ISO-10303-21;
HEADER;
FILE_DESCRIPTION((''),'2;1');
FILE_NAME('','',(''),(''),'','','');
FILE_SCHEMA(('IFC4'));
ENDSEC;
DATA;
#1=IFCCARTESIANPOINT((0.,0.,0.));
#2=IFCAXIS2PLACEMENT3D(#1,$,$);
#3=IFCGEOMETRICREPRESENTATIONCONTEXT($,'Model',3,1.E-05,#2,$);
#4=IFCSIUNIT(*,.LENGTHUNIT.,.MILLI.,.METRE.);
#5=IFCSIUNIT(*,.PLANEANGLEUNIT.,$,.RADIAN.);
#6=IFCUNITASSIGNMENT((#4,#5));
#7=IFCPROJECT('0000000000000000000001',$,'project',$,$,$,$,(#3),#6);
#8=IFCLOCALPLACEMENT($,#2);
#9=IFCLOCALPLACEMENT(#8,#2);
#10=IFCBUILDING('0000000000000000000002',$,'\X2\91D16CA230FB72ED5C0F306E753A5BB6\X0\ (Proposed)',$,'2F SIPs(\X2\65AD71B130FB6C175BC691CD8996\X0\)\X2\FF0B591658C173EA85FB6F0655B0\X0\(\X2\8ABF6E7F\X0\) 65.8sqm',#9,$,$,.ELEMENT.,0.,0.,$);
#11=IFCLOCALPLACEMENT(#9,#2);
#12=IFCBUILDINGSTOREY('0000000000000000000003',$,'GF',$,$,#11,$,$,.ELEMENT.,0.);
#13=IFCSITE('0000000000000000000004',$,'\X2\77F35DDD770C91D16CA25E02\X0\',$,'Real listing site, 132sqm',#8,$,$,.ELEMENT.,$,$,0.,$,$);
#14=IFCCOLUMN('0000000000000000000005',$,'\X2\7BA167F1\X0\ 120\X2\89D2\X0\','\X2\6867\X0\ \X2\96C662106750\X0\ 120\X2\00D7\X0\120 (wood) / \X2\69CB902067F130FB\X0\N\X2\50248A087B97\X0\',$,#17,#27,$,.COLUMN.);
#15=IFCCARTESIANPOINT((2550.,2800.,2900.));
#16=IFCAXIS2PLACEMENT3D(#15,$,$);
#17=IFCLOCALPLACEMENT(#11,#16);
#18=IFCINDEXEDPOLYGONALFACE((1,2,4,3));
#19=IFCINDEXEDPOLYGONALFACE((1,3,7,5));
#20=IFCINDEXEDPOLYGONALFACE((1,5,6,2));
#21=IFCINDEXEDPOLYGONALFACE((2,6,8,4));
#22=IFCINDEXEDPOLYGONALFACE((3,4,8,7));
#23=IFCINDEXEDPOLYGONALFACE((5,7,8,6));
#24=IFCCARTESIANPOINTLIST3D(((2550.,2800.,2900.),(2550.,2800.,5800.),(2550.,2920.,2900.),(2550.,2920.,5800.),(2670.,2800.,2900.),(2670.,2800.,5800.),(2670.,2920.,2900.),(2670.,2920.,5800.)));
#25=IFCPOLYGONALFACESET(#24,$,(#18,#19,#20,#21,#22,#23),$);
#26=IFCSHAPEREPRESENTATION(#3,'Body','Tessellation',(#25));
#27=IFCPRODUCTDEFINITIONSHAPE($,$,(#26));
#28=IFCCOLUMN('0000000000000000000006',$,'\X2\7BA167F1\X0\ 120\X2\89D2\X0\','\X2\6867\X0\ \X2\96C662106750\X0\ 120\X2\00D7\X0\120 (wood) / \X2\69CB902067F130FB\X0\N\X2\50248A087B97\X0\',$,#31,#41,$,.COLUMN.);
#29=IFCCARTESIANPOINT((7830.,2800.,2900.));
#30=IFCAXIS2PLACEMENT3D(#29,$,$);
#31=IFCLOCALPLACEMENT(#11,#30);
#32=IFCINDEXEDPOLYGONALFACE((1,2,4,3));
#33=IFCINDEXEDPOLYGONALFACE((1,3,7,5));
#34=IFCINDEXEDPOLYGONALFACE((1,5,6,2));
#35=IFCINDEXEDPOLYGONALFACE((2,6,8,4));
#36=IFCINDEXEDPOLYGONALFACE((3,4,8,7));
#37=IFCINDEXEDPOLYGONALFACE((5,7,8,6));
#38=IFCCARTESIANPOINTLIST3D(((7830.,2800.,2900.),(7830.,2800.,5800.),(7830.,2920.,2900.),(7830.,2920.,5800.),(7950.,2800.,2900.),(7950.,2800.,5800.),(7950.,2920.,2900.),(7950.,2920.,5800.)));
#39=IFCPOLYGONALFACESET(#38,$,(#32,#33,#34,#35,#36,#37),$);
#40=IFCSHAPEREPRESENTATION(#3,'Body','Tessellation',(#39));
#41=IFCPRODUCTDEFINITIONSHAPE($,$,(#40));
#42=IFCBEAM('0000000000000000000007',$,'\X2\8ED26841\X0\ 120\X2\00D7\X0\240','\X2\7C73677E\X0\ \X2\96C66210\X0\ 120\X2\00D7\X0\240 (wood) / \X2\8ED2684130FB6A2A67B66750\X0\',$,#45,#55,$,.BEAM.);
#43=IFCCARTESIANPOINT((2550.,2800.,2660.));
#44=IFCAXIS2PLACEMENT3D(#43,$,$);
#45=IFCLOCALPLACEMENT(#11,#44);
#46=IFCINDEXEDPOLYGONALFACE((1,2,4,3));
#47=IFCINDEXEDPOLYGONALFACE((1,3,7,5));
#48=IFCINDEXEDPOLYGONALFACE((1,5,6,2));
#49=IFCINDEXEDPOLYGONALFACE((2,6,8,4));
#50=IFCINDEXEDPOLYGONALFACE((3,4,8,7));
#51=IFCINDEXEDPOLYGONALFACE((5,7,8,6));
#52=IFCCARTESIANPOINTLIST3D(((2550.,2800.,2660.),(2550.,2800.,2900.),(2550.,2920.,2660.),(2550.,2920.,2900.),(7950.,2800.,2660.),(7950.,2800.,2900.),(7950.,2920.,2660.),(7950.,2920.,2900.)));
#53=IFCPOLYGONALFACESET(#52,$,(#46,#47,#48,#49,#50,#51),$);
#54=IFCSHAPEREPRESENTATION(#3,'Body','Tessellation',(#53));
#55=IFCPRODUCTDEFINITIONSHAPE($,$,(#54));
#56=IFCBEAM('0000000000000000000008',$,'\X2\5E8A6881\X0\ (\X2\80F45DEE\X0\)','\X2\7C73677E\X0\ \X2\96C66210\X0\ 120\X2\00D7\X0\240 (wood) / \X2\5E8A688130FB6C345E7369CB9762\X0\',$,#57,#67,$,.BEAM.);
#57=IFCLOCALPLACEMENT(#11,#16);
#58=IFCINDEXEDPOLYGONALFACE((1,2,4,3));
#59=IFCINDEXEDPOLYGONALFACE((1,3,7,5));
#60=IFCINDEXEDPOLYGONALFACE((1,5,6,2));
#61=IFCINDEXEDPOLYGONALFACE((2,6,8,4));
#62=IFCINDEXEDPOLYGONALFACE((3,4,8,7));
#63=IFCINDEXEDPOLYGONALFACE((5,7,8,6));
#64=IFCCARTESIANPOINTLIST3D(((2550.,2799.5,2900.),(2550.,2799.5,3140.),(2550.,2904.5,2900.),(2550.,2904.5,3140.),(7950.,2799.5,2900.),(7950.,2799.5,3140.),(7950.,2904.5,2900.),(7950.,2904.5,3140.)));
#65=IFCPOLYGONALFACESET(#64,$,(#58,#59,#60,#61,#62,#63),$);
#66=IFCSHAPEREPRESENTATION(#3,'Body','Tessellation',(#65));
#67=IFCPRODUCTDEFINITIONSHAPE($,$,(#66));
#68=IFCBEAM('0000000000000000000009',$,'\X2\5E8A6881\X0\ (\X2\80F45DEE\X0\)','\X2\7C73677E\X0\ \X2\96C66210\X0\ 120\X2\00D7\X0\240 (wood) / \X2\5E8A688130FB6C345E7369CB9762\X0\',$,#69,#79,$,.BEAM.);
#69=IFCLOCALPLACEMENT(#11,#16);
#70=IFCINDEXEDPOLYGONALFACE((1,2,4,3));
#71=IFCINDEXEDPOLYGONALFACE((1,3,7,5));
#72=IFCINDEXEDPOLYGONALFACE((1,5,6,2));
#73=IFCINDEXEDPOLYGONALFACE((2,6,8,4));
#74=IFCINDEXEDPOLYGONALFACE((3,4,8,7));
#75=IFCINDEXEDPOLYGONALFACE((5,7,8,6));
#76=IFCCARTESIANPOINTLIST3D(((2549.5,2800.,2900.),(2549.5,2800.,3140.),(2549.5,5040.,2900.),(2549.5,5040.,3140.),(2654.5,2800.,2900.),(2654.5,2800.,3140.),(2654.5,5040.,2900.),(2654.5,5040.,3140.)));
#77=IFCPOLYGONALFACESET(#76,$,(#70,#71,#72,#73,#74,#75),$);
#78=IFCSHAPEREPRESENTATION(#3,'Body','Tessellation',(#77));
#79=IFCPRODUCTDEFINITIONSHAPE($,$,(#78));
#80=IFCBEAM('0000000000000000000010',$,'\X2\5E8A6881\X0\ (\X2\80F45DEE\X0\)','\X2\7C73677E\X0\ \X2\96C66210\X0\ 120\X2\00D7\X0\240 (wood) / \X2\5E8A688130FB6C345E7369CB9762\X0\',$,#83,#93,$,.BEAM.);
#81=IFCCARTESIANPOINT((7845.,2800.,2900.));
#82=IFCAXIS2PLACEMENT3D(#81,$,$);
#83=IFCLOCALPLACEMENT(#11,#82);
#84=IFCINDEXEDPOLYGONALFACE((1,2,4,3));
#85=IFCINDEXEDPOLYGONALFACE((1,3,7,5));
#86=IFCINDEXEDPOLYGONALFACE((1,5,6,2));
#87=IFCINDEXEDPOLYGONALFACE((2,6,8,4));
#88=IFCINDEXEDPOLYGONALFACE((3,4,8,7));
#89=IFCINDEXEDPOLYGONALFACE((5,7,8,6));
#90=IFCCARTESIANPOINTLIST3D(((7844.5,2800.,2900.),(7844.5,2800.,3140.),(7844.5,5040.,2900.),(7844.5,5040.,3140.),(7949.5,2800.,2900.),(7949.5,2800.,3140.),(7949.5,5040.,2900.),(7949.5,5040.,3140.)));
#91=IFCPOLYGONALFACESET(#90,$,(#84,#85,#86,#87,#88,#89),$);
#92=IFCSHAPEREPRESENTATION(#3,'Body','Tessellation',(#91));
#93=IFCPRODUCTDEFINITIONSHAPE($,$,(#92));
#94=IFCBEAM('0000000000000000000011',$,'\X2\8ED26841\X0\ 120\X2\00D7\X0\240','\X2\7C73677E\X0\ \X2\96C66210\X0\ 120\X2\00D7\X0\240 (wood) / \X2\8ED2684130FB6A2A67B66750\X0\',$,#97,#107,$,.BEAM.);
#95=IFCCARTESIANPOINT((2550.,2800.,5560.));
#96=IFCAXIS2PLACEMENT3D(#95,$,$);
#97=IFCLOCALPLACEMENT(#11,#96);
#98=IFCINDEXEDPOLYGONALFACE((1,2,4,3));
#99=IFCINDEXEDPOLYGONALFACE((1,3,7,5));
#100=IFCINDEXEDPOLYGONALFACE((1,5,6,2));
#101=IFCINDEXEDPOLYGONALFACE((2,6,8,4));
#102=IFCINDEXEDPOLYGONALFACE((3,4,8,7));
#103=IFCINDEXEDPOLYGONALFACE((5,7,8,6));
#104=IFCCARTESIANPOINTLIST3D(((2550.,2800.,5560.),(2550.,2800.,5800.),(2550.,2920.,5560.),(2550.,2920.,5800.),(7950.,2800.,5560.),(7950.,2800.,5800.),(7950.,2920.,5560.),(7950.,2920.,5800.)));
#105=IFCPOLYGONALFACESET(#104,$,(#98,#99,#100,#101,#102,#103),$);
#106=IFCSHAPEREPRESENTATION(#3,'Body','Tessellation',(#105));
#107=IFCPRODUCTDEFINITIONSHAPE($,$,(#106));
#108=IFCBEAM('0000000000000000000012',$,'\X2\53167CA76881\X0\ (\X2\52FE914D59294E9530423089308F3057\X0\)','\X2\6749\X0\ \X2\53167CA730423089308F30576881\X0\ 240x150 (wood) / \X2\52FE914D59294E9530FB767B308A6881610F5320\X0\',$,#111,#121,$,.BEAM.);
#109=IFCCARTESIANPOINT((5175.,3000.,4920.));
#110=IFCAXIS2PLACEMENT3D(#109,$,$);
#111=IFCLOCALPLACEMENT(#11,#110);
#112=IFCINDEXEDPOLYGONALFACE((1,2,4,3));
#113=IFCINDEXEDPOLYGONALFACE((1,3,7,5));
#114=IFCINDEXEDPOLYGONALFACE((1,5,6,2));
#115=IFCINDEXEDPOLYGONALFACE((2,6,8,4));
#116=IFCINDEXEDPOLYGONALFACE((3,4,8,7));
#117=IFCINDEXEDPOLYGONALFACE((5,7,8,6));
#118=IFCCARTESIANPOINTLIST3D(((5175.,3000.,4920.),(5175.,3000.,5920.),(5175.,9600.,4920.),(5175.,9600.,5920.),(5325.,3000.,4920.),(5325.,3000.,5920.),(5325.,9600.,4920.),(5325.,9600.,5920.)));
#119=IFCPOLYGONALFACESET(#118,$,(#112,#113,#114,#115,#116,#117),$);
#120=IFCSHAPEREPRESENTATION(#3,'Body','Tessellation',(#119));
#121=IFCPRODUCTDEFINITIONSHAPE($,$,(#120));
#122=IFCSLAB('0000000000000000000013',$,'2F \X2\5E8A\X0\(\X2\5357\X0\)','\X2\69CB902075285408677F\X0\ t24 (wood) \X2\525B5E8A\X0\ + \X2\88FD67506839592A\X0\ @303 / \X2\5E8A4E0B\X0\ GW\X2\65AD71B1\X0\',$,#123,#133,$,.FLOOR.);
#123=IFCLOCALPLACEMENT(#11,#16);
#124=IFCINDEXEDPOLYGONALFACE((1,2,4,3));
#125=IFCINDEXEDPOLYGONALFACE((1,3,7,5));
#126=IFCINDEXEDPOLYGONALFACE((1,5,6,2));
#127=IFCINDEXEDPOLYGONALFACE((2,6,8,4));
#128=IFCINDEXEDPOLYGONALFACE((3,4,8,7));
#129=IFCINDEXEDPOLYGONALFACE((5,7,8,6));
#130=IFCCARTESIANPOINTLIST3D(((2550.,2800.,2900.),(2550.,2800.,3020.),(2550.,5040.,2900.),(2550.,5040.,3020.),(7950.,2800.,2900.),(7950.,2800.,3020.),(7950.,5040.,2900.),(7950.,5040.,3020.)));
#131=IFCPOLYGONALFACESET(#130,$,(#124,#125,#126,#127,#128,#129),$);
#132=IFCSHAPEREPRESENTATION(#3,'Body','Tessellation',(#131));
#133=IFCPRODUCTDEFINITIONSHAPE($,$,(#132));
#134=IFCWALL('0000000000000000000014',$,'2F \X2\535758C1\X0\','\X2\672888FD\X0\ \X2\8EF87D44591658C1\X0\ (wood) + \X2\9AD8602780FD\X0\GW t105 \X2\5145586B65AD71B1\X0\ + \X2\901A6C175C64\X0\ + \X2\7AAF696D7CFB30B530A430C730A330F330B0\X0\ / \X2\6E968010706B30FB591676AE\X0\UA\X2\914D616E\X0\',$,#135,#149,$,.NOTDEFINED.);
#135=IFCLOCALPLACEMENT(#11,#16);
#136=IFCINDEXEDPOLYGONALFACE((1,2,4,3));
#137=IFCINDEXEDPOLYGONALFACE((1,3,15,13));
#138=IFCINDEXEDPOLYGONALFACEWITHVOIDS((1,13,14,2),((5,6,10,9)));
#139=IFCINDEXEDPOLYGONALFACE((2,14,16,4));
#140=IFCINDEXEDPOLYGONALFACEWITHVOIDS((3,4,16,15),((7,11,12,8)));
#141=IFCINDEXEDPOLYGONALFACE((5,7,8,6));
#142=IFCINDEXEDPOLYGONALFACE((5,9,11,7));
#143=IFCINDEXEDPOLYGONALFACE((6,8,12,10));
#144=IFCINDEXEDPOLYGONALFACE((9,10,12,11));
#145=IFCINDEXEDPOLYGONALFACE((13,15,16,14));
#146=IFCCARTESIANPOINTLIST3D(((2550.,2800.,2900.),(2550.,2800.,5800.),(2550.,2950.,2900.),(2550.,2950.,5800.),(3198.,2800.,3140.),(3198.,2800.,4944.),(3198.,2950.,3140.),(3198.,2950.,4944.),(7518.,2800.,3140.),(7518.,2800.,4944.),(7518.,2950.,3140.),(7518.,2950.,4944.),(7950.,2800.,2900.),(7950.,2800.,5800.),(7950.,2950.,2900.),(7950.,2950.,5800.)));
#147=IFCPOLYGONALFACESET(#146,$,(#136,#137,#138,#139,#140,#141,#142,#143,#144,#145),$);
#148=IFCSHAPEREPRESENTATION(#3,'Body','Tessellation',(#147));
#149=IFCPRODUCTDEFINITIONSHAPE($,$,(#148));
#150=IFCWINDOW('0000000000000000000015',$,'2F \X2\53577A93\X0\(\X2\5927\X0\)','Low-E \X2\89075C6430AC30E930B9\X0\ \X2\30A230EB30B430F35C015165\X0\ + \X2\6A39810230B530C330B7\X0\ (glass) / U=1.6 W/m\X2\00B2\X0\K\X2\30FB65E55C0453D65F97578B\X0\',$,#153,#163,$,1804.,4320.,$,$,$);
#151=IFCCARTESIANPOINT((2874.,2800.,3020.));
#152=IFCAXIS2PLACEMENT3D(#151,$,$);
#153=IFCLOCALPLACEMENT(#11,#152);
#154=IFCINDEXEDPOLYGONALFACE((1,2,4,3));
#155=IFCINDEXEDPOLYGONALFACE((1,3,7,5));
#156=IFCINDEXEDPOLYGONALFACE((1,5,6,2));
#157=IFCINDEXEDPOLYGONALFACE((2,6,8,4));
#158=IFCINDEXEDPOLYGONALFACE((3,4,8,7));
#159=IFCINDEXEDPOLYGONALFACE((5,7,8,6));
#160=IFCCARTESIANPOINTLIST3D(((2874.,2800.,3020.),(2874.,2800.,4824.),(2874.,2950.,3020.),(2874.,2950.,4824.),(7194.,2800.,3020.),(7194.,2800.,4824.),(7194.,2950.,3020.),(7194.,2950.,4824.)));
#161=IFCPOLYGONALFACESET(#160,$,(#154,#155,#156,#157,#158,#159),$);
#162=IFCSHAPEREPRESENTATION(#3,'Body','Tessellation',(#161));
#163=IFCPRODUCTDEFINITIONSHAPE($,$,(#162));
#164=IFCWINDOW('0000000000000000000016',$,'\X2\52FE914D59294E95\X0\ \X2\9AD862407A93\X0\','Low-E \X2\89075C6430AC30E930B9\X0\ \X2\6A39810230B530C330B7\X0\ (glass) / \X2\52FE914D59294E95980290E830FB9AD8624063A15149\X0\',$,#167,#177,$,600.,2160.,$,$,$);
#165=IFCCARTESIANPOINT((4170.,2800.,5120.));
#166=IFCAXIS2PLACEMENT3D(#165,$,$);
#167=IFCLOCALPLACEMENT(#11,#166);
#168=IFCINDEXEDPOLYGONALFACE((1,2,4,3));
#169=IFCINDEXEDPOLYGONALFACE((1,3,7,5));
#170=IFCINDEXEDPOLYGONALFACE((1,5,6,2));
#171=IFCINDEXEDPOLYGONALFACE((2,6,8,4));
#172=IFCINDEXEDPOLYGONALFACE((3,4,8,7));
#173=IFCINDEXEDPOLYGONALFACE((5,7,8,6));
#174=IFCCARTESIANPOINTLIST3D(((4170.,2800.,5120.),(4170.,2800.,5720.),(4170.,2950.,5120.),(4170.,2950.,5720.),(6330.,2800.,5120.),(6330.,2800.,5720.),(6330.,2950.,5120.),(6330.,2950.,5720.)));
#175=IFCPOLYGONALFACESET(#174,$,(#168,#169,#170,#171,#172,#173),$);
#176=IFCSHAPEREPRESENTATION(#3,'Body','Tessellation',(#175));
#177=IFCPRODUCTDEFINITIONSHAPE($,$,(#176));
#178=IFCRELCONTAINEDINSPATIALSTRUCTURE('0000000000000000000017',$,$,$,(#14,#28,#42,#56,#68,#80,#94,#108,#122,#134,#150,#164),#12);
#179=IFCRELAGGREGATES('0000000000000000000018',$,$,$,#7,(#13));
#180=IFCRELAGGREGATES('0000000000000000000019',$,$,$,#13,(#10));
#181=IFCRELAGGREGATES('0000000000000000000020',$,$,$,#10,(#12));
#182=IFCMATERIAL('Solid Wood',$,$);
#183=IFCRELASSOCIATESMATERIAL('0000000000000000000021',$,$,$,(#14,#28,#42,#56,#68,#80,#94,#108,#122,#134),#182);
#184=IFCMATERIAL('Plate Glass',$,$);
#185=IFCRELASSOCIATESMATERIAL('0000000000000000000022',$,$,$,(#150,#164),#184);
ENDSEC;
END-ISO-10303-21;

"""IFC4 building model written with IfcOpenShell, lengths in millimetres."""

from ifc_helpers import new_model, si_unit, frame, frame_2d, origin, place, context, project, spatial, rectangle, extrude, material, element, fill, save


model = new_model("IFC4")

# Units and contexts
model_context = context("Model", 3, precision=1e-05, world=origin())
ifc_project = project(units=[si_unit("LENGTHUNIT", "METRE", prefix="MILLI"), si_unit("PLANEANGLEUNIT", "RADIAN")], contexts=[model_context])

# Site, building, storey
site_placement = place(None, origin())
site = spatial("IfcSite", under=ifc_project, at=site_placement, Name="石川県金沢市", ObjectType="Real listing site, 132sqm", CompositionType="ELEMENT", RefElevation=0.0)
building_placement = place(site_placement, origin())
building = spatial("IfcBuilding", under=site, at=building_placement, Name="金沢・狭小の町家 (Proposed)", ObjectType="2F SIPs(断熱・気密重視)＋外壁珪藻漆喰(調湿) 65.8sqm", CompositionType="ELEMENT", ElevationOfRefHeight=0.0, ElevationOfTerrain=0.0)
storey_placement = place(building_placement, origin())
storey = spatial("IfcBuildingStorey", under=building, at=storey_placement, Name="GF", CompositionType="ELEMENT", Elevation=0.0)

# Columns
ifc_material_1 = material(Name="Solid Wood")
column_1_placement = place(storey_placement, frame((2550.0, 2800.0, 2900.0)))
element("IfcColumn", 1, at=column_1_placement, inside=storey, material=ifc_material_1, Name="管柱 120角", Description="桧 集成材 120×120 (wood) / 構造柱・N値計算", PredefinedType="COLUMN", context=model_context, shape_type="SweptSolid", body=[
    extrude(rectangle(XDim=120.0, YDim=120.0, at=frame_2d((60.0, 60.0))), frame((2550.0, 2800.0, 2900.0)), (0.0, 0.0, 1.0), 2900.0),
])
column_2_placement = place(storey_placement, frame((7830.0, 2800.0, 2900.0)))
element("IfcColumn", 2, at=column_2_placement, inside=storey, material=ifc_material_1, Name="管柱 120角", Description="桧 集成材 120×120 (wood) / 構造柱・N値計算", PredefinedType="COLUMN", context=model_context, shape_type="SweptSolid", body=[
    extrude(rectangle(XDim=120.0, YDim=120.0, at=frame_2d((60.0, 60.0))), frame((7830.0, 2800.0, 2900.0)), (0.0, 0.0, 1.0), 2900.0),
])

# Beams
beam_1_placement = place(storey_placement, frame((2550.0, 2800.0, 2660.0)))
element("IfcBeam", 3, at=beam_1_placement, inside=storey, material=ifc_material_1, Name="軒桁 120×240", Description="米松 集成 120×240 (wood) / 軒桁・横架材", PredefinedType="BEAM", context=model_context, shape_type="SweptSolid", body=[
    extrude(rectangle(XDim=5400.0, YDim=120.0, at=frame_2d((2700.0, 60.0))), frame((2550.0, 2800.0, 2660.0)), (0.0, 0.0, 1.0), 240.0),
])
beam_2_placement = place(storey_placement, frame((2550.0, 2800.0, 2900.0)))
element("IfcBeam", 4, at=beam_2_placement, inside=storey, material=ifc_material_1, Name="床梁 (胴差)", Description="米松 集成 120×240 (wood) / 床梁・水平構面", PredefinedType="BEAM", context=model_context, shape_type="SweptSolid", body=[
    extrude(rectangle(XDim=5400.0, YDim=105.0, at=frame_2d((2700.0, 52.0))), frame((2550.0, 2800.0, 2900.0)), (0.0, 0.0, 1.0), 240.0),
])
beam_3_placement = place(storey_placement, frame((2550.0, 2800.0, 2900.0)))
element("IfcBeam", 5, at=beam_3_placement, inside=storey, material=ifc_material_1, Name="床梁 (胴差)", Description="米松 集成 120×240 (wood) / 床梁・水平構面", PredefinedType="BEAM", context=model_context, shape_type="SweptSolid", body=[
    extrude(rectangle(XDim=105.0, YDim=2240.0, at=frame_2d((52.0, 1120.0))), frame((2550.0, 2800.0, 2900.0)), (0.0, 0.0, 1.0), 240.0),
])
beam_4_placement = place(storey_placement, frame((7845.0, 2800.0, 2900.0)))
element("IfcBeam", 6, at=beam_4_placement, inside=storey, material=ifc_material_1, Name="床梁 (胴差)", Description="米松 集成 120×240 (wood) / 床梁・水平構面", PredefinedType="BEAM", context=model_context, shape_type="SweptSolid", body=[
    extrude(rectangle(XDim=105.0, YDim=2240.0, at=frame_2d((52.0, 1120.0))), frame((7845.0, 2800.0, 2900.0)), (0.0, 0.0, 1.0), 240.0),
])
beam_5_placement = place(storey_placement, frame((2550.0, 2800.0, 5560.0)))
element("IfcBeam", 7, at=beam_5_placement, inside=storey, material=ifc_material_1, Name="軒桁 120×240", Description="米松 集成 120×240 (wood) / 軒桁・横架材", PredefinedType="BEAM", context=model_context, shape_type="SweptSolid", body=[
    extrude(rectangle(XDim=5400.0, YDim=120.0, at=frame_2d((2700.0, 60.0))), frame((2550.0, 2800.0, 5560.0)), (0.0, 0.0, 1.0), 240.0),
])
beam_6_placement = place(storey_placement, frame((5175.0, 3000.0, 4920.0)))
element("IfcBeam", 8, at=beam_6_placement, inside=storey, material=ifc_material_1, Name="化粧梁 (勾配天井あらわし)", Description="杉 化粧あらわし梁 240x150 (wood) / 勾配天井・登り梁意匠", PredefinedType="BEAM", context=model_context, shape_type="SweptSolid", body=[
    extrude(rectangle(XDim=150.0, YDim=6600.0, at=frame_2d((75.0, 3300.0))), frame((5175.0, 3000.0, 4920.0)), (0.0, 0.0, 1.0), 1000.0),
])

# Slab
slab_placement = place(storey_placement, frame((2550.0, 2800.0, 2900.0)))
element("IfcSlab", 9, at=slab_placement, inside=storey, material=ifc_material_1, Name="2F 床(南)", Description="構造用合板 t24 (wood) 剛床 + 製材根太 @303 / 床下 GW断熱", PredefinedType="FLOOR", context=model_context, shape_type="SweptSolid", body=[
    extrude(rectangle(XDim=5400.0, YDim=2240.0, at=frame_2d((2700.0, 1120.0))), frame((2550.0, 2800.0, 2900.0)), (0.0, 0.0, 1.0), 120.0),
])

# Wall, openings, windows
wall_1_placement = place(storey_placement, frame((2550.0, 2800.0, 2900.0)))
wall_1 = element("IfcWall", 10, at=wall_1_placement, inside=storey, material=ifc_material_1, Name="2F 南壁", Description="木製 軸組外壁 (wood) + 高性能GW t105 充填断熱 + 通気層 + 窯業系サイディング / 準耐火・外皮UA配慮", PredefinedType="NOTDEFINED", context=model_context, shape_type="SweptSolid", body=[
    extrude(rectangle(XDim=5400.0, YDim=150.0, at=frame_2d((2700.0, 75.0))), frame((2550.0, 2800.0, 2900.0)), (0.0, 0.0, 1.0), 2900.0),
])
opening_1_placement = place(storey_placement, frame((2874.0, 2800.0, 3020.0)))
opening_1 = element("IfcOpeningElement", 11, at=opening_1_placement, cuts=wall_1, PredefinedType="NOTDEFINED", context=model_context, shape_type="SweptSolid", body=[
    extrude(rectangle(XDim=4320.0, YDim=150.0, at=frame_2d((2160.0, 75.0))), frame((2874.0, 2800.0, 3020.0)), (0.0, 0.0, 1.0), 1804.0),
])
opening_2_placement = place(storey_placement, frame((4170.0, 2800.0, 5120.0)))
opening_2 = element("IfcOpeningElement", 12, at=opening_2_placement, cuts=wall_1, PredefinedType="NOTDEFINED", context=model_context, shape_type="SweptSolid", body=[
    extrude(rectangle(XDim=2160.0, YDim=150.0, at=frame_2d((1080.0, 75.0))), frame((4170.0, 2800.0, 5120.0)), (0.0, 0.0, 1.0), 600.0),
])
ifc_material_2 = material(Name="Plate Glass")
window_1_placement = place(storey_placement, frame((2874.0, 2800.0, 3020.0)))
window_1 = element("IfcWindow", 13, at=window_1_placement, inside=storey, material=ifc_material_2, Name="2F 南窓(大)", Description="Low-E 複層ガラス アルゴン封入 + 樹脂サッシ (glass) / U=1.6 W/m²K・日射取得型", OverallHeight=1804.0, OverallWidth=4320.0, context=model_context, shape_type="SweptSolid", body=[
    extrude(rectangle(XDim=4320.0, YDim=150.0, at=frame_2d((2160.0, 75.0))), frame((2874.0, 2800.0, 3020.0)), (0.0, 0.0, 1.0), 1804.0),
])
fill(opening_1, window_1)
window_2_placement = place(storey_placement, frame((4170.0, 2800.0, 5120.0)))
window_2 = element("IfcWindow", 14, at=window_2_placement, inside=storey, material=ifc_material_2, Name="勾配天井 高所窓", Description="Low-E 複層ガラス 樹脂サッシ (glass) / 勾配天井頂部・高所採光", OverallHeight=600.0, OverallWidth=2160.0, context=model_context, shape_type="SweptSolid", body=[
    extrude(rectangle(XDim=2160.0, YDim=150.0, at=frame_2d((1080.0, 75.0))), frame((4170.0, 2800.0, 5120.0)), (0.0, 0.0, 1.0), 600.0),
])
fill(opening_2, window_2)

save(model, "model.ifc")
